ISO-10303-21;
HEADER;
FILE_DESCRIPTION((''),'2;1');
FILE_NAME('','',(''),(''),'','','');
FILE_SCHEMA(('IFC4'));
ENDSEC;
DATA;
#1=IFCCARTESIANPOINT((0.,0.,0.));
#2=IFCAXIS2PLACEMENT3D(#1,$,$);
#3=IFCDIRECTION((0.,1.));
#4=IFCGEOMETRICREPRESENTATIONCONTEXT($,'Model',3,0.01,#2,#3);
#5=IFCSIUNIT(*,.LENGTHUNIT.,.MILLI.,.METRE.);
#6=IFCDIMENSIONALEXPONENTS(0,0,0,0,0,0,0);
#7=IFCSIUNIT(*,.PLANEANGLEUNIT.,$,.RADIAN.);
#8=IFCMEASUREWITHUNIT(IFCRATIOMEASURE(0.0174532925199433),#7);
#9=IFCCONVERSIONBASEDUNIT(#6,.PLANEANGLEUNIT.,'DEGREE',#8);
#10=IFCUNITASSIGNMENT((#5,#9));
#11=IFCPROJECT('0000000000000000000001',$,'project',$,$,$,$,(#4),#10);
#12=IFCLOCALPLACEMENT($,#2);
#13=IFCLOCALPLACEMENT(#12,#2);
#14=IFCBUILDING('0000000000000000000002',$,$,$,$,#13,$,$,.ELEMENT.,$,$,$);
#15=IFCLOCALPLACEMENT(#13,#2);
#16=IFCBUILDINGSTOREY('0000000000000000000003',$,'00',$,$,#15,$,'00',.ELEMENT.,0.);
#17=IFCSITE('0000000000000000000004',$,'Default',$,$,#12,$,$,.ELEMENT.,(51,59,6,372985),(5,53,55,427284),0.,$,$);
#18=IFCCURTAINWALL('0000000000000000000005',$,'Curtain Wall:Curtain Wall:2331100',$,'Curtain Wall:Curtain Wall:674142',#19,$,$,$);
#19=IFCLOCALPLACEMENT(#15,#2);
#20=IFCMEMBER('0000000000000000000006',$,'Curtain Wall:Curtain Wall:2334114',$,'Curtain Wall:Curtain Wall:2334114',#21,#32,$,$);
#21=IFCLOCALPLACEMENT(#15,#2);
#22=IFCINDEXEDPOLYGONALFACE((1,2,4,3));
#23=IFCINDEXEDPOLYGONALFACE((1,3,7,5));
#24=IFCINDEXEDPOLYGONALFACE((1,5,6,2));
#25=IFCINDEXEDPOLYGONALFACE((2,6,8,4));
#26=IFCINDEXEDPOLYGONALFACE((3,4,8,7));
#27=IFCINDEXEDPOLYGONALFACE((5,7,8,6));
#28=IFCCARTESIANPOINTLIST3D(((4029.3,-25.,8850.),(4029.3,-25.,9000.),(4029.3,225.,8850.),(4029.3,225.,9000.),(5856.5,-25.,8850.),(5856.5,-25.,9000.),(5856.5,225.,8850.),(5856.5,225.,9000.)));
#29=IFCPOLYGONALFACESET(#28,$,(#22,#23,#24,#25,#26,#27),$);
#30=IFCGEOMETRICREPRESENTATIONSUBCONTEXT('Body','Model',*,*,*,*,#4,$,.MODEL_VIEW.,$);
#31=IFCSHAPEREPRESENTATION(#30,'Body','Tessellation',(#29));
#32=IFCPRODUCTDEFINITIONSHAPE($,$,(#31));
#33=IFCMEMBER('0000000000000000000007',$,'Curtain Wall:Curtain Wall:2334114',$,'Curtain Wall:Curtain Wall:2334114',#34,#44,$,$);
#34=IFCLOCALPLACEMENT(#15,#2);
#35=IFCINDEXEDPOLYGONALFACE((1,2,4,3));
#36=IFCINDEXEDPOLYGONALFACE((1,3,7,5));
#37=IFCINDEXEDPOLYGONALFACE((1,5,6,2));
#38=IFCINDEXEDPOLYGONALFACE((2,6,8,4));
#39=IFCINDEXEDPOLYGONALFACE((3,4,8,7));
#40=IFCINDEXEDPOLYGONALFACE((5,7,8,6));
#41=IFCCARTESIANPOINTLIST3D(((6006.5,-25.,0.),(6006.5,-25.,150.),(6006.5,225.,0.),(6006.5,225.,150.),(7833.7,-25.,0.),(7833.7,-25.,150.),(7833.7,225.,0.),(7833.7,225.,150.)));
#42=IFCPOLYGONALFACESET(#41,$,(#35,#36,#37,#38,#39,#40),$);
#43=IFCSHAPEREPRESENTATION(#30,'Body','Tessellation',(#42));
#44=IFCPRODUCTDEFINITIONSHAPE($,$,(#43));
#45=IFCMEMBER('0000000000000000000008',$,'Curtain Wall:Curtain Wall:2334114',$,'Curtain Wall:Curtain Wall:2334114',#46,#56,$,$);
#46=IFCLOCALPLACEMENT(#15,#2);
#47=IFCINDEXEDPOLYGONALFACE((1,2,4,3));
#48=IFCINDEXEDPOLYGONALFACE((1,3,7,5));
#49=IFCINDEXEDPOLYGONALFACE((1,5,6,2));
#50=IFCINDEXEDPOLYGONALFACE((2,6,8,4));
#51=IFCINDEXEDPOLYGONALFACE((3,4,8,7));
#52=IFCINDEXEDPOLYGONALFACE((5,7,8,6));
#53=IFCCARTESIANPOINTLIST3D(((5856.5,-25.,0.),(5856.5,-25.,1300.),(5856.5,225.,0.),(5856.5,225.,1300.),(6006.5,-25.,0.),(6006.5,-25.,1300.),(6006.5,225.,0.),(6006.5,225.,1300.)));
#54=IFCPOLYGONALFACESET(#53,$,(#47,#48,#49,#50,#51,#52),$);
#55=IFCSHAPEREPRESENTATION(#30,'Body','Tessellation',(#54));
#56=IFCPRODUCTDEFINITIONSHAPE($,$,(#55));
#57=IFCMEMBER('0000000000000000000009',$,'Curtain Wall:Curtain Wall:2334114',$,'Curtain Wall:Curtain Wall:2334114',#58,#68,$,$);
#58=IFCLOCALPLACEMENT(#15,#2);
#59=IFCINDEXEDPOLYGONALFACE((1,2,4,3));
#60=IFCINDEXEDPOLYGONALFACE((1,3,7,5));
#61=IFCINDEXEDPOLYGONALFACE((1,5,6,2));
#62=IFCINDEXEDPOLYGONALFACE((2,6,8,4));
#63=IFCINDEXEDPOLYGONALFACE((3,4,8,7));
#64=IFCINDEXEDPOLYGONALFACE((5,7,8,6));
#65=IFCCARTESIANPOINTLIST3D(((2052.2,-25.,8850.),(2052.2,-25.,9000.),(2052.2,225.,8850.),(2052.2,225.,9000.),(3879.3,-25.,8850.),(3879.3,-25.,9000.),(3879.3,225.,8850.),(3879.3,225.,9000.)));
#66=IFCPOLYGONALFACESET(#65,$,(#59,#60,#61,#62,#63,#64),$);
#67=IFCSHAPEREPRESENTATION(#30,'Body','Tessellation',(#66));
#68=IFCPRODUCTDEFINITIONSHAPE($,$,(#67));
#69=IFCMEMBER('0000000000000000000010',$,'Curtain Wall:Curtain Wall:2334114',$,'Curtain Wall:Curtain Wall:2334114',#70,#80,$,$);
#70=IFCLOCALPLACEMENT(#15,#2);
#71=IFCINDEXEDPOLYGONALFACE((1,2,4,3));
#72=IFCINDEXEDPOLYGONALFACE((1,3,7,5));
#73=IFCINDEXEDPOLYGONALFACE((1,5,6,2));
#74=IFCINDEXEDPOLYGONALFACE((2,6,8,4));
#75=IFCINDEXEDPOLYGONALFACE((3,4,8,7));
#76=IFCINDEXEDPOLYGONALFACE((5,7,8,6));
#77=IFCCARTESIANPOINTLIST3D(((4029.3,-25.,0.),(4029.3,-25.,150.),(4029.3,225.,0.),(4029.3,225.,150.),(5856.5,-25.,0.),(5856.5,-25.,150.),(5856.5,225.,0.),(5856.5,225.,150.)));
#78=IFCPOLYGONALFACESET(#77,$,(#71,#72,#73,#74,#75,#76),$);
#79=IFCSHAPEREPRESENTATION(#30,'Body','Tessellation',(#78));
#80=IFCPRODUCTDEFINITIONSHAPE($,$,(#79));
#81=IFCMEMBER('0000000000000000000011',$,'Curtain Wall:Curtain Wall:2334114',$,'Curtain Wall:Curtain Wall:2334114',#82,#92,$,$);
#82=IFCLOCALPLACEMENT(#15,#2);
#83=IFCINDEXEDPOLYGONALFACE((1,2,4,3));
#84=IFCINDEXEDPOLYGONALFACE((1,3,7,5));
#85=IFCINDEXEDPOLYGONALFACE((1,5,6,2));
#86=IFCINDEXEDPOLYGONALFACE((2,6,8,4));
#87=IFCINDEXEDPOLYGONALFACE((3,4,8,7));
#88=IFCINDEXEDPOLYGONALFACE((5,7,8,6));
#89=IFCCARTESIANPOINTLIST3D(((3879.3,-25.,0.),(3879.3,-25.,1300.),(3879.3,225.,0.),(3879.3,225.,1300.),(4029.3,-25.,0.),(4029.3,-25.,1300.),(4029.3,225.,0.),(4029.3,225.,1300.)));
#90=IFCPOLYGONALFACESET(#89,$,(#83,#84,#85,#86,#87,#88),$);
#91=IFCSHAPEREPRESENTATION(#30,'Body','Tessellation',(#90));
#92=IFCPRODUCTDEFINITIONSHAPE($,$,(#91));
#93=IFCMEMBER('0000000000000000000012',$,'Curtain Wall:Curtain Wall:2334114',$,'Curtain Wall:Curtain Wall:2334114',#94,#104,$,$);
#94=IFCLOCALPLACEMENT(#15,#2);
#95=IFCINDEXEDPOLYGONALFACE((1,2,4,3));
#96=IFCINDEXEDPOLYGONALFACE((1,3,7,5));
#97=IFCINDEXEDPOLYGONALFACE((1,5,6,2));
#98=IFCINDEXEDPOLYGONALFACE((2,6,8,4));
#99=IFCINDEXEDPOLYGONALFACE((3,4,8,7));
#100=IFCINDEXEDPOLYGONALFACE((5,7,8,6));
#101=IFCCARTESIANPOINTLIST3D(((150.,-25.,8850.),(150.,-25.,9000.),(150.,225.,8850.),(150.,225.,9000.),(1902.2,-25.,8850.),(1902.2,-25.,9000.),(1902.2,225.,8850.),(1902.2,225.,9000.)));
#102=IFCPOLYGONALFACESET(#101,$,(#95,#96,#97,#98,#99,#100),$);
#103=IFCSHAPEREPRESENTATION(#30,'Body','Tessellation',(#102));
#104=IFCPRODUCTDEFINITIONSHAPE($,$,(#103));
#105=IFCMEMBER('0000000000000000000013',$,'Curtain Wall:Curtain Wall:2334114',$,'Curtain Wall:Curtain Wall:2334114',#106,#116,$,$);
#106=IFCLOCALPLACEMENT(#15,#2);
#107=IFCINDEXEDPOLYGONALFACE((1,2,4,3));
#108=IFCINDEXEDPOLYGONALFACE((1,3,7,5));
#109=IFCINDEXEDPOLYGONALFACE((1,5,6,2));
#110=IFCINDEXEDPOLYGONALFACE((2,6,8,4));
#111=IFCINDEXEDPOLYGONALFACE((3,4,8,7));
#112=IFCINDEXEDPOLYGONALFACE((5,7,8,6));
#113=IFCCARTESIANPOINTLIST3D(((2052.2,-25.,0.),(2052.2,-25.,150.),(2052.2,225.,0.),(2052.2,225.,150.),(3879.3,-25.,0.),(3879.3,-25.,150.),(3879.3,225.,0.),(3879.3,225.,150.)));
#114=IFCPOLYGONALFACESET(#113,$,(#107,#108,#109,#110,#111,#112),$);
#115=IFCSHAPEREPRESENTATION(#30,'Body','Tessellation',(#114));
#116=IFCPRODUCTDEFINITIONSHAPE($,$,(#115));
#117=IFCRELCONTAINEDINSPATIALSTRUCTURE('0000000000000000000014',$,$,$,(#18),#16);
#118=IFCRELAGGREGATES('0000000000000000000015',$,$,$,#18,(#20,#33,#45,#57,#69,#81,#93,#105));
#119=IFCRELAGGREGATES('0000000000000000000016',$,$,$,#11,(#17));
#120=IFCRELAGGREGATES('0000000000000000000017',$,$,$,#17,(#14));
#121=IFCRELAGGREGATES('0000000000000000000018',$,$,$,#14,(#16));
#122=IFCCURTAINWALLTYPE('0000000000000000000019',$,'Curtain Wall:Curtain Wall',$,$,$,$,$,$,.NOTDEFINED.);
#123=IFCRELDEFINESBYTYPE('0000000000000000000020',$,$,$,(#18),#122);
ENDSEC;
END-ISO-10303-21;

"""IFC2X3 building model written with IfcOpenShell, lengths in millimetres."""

from ifc_helpers import new_model, entity, si_unit, converted_unit, direction, frame, frame_2d, origin, place, context, subcontext, project, spatial, rectangle, extrude, type_object, element, aggregate, save


model = new_model("IFC2X3")

# Units and contexts
model_context = context("Model", 3, precision=0.01, world=origin(), true_north=direction((0.0, 1.0)))
body_context = subcontext(model_context, "Body", "Model", "MODEL_VIEW")
ifc_project = project(units=[si_unit("LENGTHUNIT", "METRE", prefix="MILLI"), converted_unit("PLANEANGLEUNIT", "DEGREE", entity("IfcRatioMeasure", 0.0174532925199433), si_unit("PLANEANGLEUNIT", "RADIAN"), dimensions=[0, 0, 0, 0, 0, 0, 0])], contexts=[model_context])

# Site, building, storey
site_placement = place(None, origin())
site = spatial("IfcSite", under=ifc_project, at=site_placement, Name="Default", CompositionType="ELEMENT", RefLatitude=(51, 59, 6, 372985), RefLongitude=(5, 53, 55, 427284), RefElevation=0.0)
building_placement = place(site_placement, origin())
building = spatial("IfcBuilding", under=site, at=building_placement, CompositionType="ELEMENT")
storey_placement = place(building_placement, origin())
storey = spatial("IfcBuildingStorey", under=building, at=storey_placement, Name="00", LongName="00", CompositionType="ELEMENT", Elevation=0.0)

# Curtain wall, members
curtain_wall_type = type_object("IfcCurtainWallType", Name="Curtain Wall:Curtain Wall", PredefinedType="NOTDEFINED")
curtain_wall_placement = place(storey_placement, origin())
curtain_wall = element("IfcCurtainWall", 1, at=curtain_wall_placement, inside=storey, type_object=curtain_wall_type, Name="Curtain Wall:Curtain Wall:2331100", ObjectType="Curtain Wall:Curtain Wall:674142")
member_1_placement = place(curtain_wall_placement, origin())
member_1 = element("IfcMember", 2, at=member_1_placement, Name="Curtain Wall:Curtain Wall:2334114", ObjectType="Curtain Wall:Curtain Wall:2334114", context=body_context, shape_type="SweptSolid", body=[
    extrude(rectangle(XDim=150.0, YDim=250.0, at=frame_2d((0.0, 0.0), x_axis=(1.0, 0.0))), frame((5856.5, 100.0, 8925.0), z_axis=(-1.0, 0.0, 0.0), x_axis=(0.0, 0.0, -1.0)), (0.0, 0.0, 1.0), 1827.2),
])
member_2_placement = place(curtain_wall_placement, origin())
member_2 = element("IfcMember", 3, at=member_2_placement, Name="Curtain Wall:Curtain Wall:2334114", ObjectType="Curtain Wall:Curtain Wall:2334114", context=body_context, shape_type="SweptSolid", body=[
    extrude(rectangle(XDim=150.0, YDim=250.0, at=frame_2d((0.0, 0.0), x_axis=(1.0, 0.0))), frame((6006.5, 100.0, 75.0), z_axis=(1.0, 0.0, 0.0), x_axis=(0.0, 0.0, -1.0)), (0.0, 0.0, 1.0), 1827.2),
])
member_3_placement = place(curtain_wall_placement, origin())
member_3 = element("IfcMember", 4, at=member_3_placement, Name="Curtain Wall:Curtain Wall:2334114", ObjectType="Curtain Wall:Curtain Wall:2334114", context=body_context, shape_type="SweptSolid", body=[
    extrude(rectangle(XDim=150.0, YDim=250.0, at=frame_2d((0.0, 0.0), x_axis=(1.0, 0.0))), frame((5931.5, 100.0, 0.0), z_axis=(0.0, 0.0, 1.0), x_axis=(-1.0, 0.0, 0.0)), (0.0, 0.0, 1.0), 1300.0),
])
member_4_placement = place(curtain_wall_placement, origin())
member_4 = element("IfcMember", 5, at=member_4_placement, Name="Curtain Wall:Curtain Wall:2334114", ObjectType="Curtain Wall:Curtain Wall:2334114", context=body_context, shape_type="SweptSolid", body=[
    extrude(rectangle(XDim=150.0, YDim=250.0, at=frame_2d((0.0, 0.0), x_axis=(1.0, 0.0))), frame((3879.3, 100.0, 8925.0), z_axis=(-1.0, 0.0, 0.0), x_axis=(0.0, 0.0, -1.0)), (0.0, 0.0, 1.0), 1827.2),
])
member_5_placement = place(curtain_wall_placement, origin())
member_5 = element("IfcMember", 6, at=member_5_placement, Name="Curtain Wall:Curtain Wall:2334114", ObjectType="Curtain Wall:Curtain Wall:2334114", context=body_context, shape_type="SweptSolid", body=[
    extrude(rectangle(XDim=150.0, YDim=250.0, at=frame_2d((0.0, 0.0), x_axis=(1.0, 0.0))), frame((4029.3, 100.0, 75.0), z_axis=(1.0, 0.0, 0.0), x_axis=(0.0, 0.0, -1.0)), (0.0, 0.0, 1.0), 1827.2),
])
member_6_placement = place(curtain_wall_placement, origin())
member_6 = element("IfcMember", 7, at=member_6_placement, Name="Curtain Wall:Curtain Wall:2334114", ObjectType="Curtain Wall:Curtain Wall:2334114", context=body_context, shape_type="SweptSolid", body=[
    extrude(rectangle(XDim=150.0, YDim=250.0, at=frame_2d((0.0, 0.0), x_axis=(1.0, 0.0))), frame((3954.3, 100.0, 0.0), z_axis=(0.0, 0.0, 1.0), x_axis=(-1.0, 0.0, 0.0)), (0.0, 0.0, 1.0), 1300.0),
])
member_7_placement = place(curtain_wall_placement, origin())
member_7 = element("IfcMember", 8, at=member_7_placement, Name="Curtain Wall:Curtain Wall:2334114", ObjectType="Curtain Wall:Curtain Wall:2334114", context=body_context, shape_type="SweptSolid", body=[
    extrude(rectangle(XDim=150.0, YDim=250.0, at=frame_2d((0.0, 0.0), x_axis=(1.0, 0.0))), frame((1902.2, 100.0, 8925.0), z_axis=(-1.0, 0.0, 0.0), x_axis=(0.0, 0.0, -1.0)), (0.0, 0.0, 1.0), 1752.2),
])
member_8_placement = place(curtain_wall_placement, origin())
member_8 = element("IfcMember", 9, at=member_8_placement, Name="Curtain Wall:Curtain Wall:2334114", ObjectType="Curtain Wall:Curtain Wall:2334114", context=body_context, shape_type="SweptSolid", body=[
    extrude(rectangle(XDim=150.0, YDim=250.0, at=frame_2d((0.0, 0.0), x_axis=(1.0, 0.0))), frame((2052.2, 100.0, 75.0), z_axis=(1.0, 0.0, 0.0), x_axis=(0.0, 0.0, -1.0)), (0.0, 0.0, 1.0), 1827.2),
])
aggregate(curtain_wall, [member_1, member_2, member_3, member_4, member_5, member_6, member_7, member_8])

save(model, "model.ifc")
